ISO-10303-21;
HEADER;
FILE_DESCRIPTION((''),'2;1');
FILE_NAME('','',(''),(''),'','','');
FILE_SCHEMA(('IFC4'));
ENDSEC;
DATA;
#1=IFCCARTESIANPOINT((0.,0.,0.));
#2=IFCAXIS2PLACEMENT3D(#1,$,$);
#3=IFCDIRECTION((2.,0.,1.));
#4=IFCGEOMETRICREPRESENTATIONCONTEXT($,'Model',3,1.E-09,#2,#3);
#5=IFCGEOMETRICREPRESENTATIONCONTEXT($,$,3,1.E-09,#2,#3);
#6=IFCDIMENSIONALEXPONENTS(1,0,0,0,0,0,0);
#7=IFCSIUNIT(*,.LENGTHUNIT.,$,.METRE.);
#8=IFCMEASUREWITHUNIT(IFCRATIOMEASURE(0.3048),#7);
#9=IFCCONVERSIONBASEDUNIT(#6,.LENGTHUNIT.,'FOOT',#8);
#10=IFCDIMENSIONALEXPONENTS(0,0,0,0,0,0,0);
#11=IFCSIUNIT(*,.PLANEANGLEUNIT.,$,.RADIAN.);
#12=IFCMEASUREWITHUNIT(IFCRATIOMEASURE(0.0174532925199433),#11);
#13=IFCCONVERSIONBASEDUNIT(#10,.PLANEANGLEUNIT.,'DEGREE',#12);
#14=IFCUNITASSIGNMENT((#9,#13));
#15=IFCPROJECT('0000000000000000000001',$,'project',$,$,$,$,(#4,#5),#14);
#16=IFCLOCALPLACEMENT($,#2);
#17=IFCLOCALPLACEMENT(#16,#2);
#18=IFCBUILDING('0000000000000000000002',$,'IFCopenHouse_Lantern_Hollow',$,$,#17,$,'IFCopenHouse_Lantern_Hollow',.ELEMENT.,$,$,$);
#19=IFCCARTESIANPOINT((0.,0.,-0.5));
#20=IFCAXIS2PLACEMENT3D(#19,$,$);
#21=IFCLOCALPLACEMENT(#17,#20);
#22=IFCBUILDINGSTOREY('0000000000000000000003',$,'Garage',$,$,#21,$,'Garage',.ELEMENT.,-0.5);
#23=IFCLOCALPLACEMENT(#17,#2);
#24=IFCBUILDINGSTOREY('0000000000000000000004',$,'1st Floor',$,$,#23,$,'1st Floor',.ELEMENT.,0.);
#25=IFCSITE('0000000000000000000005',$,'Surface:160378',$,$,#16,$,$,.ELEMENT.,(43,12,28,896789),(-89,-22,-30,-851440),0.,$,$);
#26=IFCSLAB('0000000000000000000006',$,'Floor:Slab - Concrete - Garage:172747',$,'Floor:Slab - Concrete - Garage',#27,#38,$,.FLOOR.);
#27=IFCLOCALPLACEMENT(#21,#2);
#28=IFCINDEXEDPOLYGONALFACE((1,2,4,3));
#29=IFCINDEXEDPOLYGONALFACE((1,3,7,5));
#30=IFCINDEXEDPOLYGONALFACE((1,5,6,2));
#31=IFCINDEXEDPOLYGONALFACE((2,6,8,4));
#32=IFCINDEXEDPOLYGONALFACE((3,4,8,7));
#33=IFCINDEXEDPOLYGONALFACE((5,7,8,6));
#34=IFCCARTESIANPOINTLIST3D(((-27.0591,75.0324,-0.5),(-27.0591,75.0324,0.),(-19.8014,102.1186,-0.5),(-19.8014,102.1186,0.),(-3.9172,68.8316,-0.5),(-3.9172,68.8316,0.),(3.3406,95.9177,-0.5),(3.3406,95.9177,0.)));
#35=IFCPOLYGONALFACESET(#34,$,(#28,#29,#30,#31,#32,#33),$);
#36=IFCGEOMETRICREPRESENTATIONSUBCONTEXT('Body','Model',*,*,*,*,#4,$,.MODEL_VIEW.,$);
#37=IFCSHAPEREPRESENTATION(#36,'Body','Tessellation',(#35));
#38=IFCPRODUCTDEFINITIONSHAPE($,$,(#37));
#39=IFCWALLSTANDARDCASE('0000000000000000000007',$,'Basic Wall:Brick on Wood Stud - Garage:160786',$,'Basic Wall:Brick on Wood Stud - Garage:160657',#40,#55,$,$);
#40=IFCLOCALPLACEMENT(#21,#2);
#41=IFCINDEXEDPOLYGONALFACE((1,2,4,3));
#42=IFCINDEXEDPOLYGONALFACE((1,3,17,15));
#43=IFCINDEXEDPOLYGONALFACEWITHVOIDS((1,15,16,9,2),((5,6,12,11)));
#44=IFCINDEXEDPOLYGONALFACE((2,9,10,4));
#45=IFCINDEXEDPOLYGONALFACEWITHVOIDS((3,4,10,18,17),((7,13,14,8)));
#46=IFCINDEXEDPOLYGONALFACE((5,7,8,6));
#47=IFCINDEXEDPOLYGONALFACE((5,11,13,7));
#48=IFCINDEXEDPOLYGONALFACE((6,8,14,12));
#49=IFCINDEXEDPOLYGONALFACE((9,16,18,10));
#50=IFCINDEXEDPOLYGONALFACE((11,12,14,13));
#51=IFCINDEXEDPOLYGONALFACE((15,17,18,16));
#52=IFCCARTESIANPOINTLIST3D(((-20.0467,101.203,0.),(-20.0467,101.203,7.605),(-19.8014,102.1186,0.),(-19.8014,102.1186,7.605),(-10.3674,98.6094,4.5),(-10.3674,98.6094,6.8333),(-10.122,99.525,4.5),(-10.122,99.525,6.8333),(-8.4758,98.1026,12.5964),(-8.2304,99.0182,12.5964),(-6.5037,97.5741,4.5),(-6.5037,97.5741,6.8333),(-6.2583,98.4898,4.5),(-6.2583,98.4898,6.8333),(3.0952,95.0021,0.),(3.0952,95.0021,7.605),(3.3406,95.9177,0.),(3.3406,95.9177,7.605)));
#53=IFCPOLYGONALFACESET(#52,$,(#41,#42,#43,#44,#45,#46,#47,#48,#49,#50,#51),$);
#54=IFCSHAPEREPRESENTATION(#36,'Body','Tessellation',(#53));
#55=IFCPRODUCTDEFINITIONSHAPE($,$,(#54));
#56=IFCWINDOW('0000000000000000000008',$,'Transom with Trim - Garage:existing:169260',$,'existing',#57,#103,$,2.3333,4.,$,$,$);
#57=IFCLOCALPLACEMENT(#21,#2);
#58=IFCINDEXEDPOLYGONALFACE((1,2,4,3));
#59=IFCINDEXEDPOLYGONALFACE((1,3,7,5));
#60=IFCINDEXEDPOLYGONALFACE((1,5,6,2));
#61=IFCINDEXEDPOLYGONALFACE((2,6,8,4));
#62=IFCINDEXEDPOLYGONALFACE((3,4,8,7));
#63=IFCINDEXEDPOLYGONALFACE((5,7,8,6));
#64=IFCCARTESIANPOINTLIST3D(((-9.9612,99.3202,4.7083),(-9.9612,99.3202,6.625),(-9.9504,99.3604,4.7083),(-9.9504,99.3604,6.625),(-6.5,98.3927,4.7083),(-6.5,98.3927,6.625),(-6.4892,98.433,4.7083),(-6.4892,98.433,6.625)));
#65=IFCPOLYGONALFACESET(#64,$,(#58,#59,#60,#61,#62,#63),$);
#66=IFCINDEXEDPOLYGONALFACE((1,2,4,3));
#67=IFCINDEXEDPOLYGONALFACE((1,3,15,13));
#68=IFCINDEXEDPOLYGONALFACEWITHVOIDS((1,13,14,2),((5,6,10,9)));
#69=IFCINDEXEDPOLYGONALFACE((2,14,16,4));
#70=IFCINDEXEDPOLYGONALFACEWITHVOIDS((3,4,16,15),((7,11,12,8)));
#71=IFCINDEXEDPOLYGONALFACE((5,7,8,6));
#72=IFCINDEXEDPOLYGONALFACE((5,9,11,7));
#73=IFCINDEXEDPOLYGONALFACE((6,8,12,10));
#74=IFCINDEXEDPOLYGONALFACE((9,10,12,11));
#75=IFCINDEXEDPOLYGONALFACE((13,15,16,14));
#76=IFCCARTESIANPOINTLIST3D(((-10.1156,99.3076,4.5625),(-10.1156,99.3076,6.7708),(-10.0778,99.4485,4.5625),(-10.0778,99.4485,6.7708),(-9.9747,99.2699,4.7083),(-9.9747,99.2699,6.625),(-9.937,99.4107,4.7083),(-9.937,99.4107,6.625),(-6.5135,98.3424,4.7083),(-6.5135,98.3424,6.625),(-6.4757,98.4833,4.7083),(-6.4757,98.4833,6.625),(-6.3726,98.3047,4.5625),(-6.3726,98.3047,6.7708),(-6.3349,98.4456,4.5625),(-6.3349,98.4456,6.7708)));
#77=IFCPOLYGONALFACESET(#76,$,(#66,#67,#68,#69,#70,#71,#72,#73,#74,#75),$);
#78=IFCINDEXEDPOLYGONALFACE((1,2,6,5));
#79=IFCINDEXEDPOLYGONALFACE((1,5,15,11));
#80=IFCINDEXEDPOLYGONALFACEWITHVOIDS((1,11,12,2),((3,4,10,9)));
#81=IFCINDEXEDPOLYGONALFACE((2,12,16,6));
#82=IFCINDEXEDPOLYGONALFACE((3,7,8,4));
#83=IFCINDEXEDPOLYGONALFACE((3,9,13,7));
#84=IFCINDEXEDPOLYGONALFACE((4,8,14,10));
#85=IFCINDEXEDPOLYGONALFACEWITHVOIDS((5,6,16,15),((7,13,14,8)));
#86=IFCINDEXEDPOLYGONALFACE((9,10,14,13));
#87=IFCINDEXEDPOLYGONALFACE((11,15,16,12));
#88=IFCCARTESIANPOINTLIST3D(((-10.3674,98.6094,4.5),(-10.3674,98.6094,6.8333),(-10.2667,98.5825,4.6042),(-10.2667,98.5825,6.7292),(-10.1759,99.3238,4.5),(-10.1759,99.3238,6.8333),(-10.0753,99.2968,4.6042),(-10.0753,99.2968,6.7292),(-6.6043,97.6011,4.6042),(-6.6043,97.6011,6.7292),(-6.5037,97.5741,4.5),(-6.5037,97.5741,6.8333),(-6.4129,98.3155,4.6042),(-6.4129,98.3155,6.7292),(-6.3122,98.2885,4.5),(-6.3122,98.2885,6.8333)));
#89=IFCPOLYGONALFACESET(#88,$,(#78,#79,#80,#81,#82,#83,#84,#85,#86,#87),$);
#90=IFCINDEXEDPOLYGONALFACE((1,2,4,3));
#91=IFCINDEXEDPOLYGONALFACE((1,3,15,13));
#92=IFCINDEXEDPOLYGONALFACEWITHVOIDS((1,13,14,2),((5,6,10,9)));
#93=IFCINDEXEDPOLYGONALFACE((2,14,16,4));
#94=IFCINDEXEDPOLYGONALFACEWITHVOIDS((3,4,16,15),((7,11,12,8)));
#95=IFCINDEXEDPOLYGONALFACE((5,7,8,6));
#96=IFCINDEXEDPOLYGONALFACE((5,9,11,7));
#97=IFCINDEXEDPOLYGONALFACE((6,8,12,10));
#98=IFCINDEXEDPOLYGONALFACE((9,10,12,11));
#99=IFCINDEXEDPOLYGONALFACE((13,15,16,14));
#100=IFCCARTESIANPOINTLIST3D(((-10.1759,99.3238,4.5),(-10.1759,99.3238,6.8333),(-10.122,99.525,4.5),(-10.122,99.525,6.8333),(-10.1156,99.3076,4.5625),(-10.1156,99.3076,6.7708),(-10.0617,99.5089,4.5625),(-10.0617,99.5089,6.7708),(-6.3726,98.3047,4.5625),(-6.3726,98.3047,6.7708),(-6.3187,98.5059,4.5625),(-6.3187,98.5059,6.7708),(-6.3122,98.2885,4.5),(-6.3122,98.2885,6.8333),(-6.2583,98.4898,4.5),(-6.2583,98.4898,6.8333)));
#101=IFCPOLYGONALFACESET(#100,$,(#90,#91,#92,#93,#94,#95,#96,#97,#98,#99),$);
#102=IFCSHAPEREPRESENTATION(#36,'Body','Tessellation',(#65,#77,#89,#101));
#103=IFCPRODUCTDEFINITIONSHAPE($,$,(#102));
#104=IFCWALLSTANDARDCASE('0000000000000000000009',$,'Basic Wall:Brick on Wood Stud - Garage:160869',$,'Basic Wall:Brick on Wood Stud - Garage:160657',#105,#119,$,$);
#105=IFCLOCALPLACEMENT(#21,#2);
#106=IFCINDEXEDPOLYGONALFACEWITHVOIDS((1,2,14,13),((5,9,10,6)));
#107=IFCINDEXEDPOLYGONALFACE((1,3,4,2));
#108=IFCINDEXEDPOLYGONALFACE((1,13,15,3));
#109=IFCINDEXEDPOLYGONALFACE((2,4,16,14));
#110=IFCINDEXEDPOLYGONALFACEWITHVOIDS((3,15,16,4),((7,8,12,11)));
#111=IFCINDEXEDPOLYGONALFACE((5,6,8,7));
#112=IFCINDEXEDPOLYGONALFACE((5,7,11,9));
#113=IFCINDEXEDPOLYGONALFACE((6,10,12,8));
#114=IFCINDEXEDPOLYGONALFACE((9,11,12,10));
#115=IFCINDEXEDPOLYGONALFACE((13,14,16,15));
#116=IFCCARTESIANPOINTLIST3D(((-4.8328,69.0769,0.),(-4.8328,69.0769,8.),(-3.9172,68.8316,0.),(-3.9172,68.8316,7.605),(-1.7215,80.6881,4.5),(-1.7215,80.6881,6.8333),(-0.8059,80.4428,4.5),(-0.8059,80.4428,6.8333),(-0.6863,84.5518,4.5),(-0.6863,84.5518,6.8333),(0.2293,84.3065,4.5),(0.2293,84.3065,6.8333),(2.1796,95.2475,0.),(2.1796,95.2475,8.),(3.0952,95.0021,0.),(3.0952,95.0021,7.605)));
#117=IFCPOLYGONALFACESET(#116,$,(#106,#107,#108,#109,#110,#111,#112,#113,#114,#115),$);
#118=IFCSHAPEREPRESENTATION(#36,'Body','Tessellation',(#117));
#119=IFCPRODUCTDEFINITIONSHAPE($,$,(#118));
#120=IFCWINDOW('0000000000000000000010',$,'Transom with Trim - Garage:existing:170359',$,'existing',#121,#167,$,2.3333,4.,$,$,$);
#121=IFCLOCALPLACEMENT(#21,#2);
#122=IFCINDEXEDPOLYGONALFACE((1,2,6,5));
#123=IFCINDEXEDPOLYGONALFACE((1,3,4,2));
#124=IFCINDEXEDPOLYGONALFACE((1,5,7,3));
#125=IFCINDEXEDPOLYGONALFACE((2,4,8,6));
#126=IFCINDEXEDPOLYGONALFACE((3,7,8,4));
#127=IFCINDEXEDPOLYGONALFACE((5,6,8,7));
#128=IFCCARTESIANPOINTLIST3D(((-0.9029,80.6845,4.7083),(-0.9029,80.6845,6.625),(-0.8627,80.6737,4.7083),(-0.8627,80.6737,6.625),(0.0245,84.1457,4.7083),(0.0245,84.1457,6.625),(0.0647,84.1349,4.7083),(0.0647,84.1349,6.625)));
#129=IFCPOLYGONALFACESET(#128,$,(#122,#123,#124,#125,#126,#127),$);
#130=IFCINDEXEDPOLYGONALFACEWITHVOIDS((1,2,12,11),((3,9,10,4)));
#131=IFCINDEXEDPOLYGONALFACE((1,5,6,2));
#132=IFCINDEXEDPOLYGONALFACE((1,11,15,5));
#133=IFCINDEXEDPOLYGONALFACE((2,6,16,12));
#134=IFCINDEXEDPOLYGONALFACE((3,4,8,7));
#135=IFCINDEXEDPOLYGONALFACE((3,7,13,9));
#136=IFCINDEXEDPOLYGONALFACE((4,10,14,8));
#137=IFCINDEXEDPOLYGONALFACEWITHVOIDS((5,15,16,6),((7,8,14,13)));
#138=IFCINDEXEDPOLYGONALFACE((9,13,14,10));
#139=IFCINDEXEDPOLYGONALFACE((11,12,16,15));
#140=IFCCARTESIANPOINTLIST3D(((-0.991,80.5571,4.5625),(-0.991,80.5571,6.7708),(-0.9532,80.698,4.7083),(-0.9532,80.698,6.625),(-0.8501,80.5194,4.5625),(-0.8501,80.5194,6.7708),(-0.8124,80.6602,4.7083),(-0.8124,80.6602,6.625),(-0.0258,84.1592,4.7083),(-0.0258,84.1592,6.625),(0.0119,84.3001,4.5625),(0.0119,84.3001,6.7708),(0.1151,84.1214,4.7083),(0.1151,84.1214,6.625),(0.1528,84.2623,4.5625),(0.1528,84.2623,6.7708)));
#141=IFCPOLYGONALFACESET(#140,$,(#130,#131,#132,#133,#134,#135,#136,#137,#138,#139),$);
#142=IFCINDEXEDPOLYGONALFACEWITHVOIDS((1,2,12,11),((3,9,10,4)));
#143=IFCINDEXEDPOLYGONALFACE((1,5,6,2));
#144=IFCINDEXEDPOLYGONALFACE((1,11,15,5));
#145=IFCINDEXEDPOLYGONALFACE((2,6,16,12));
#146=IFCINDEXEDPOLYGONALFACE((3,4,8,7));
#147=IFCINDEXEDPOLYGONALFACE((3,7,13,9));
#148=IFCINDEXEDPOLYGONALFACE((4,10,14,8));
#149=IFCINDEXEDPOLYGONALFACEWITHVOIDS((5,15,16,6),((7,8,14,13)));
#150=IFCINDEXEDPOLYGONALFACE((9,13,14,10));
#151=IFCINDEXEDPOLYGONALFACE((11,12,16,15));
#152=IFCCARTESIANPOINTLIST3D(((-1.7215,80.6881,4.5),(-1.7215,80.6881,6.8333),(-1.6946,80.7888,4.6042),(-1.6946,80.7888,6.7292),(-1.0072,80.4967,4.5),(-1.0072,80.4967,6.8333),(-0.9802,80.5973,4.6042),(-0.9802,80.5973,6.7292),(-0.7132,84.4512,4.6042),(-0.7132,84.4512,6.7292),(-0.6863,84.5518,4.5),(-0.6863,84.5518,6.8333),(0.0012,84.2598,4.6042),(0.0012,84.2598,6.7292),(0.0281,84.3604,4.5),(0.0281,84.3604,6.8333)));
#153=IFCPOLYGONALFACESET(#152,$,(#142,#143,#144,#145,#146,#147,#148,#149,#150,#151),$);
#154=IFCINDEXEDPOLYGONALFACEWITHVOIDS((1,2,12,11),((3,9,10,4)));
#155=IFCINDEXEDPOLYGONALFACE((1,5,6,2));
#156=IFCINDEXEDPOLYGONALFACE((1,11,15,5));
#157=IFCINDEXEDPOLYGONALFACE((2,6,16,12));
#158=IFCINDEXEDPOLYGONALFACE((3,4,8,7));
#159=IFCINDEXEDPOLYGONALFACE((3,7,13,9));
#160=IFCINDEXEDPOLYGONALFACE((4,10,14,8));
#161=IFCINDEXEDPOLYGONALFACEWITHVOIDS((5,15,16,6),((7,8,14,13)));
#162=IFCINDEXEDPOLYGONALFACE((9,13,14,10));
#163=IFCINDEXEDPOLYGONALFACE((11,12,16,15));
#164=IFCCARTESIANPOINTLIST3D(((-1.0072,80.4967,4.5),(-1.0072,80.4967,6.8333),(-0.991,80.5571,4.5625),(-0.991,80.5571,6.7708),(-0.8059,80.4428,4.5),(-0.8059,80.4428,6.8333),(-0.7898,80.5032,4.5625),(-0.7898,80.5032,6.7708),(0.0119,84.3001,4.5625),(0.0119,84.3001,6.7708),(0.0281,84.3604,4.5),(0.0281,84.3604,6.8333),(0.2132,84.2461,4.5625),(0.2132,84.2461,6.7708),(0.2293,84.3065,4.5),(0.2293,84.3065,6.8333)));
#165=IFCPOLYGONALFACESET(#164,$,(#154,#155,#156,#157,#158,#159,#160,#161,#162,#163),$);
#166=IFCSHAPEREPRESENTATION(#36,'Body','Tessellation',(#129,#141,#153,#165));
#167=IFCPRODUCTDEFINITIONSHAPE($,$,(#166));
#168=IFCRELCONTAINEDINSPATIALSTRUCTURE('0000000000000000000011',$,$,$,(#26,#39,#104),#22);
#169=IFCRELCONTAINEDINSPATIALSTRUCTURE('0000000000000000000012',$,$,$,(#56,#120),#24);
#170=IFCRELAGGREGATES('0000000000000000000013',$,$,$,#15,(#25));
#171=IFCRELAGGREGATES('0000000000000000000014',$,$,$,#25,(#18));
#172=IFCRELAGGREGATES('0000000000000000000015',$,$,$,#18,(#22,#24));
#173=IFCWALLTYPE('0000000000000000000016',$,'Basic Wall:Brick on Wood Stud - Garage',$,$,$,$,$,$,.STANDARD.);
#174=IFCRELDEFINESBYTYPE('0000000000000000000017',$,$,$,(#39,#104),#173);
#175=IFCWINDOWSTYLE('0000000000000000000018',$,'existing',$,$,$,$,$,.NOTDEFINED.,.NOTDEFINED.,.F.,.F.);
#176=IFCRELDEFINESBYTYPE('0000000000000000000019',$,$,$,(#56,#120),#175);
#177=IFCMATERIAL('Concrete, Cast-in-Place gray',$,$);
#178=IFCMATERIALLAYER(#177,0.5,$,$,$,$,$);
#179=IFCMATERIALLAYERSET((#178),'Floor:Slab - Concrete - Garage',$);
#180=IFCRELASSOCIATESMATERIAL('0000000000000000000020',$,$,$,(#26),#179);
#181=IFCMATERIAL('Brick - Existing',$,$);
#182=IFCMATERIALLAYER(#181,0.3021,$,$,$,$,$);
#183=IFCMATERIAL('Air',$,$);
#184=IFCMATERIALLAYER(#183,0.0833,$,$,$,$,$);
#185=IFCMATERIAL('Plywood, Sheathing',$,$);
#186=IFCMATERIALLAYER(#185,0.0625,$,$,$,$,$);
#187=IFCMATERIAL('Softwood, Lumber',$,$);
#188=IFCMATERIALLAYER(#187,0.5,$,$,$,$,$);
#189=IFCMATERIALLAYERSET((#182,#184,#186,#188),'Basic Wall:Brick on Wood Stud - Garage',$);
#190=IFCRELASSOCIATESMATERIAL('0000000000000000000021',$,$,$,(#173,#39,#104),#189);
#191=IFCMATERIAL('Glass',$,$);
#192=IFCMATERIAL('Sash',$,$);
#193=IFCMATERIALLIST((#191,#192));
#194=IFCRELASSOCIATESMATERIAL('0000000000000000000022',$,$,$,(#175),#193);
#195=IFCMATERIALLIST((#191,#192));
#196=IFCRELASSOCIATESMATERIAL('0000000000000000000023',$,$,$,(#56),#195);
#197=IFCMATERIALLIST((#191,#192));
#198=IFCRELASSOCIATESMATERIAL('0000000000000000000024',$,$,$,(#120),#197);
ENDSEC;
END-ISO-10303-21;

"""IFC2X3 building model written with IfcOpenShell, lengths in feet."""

from ifc_helpers import new_model, entity, si_unit, converted_unit, direction, frame, frame_2d, origin, place, context, subcontext, project, spatial, polyline, rectangle, outline, extrude, clip, bounded_halfspace, source, transform, mapped, material, material_list, layer, layer_set, layer_usage, type_object, type_shapes, element, fill, save


model = new_model("IFC2X3")

# Units and contexts
model_context = context("Model", 3, precision=1e-09, world=origin(), true_north=direction((2.0, 0.0, 1.0)))
context_of_model = context(None, 3, precision=1e-09, world=origin(), true_north=direction((2.0, 0.0, 1.0)))
body_context = subcontext(model_context, "Body", "Model", "MODEL_VIEW")
ifc_project = project(units=[converted_unit("LENGTHUNIT", "FOOT", entity("IfcRatioMeasure", 0.3048), si_unit("LENGTHUNIT", "METRE"), dimensions=[1, 0, 0, 0, 0, 0, 0]), converted_unit("PLANEANGLEUNIT", "DEGREE", entity("IfcRatioMeasure", 0.0174532925199433), si_unit("PLANEANGLEUNIT", "RADIAN"), dimensions=[0, 0, 0, 0, 0, 0, 0])], contexts=[model_context, context_of_model])

# Site, building, storey
site_placement = place(None, origin())
site = spatial("IfcSite", under=ifc_project, at=site_placement, Name="Surface:160378", CompositionType="ELEMENT", RefLatitude=(43, 12, 28, 896789), RefLongitude=(-89, -22, -30, -851440), RefElevation=0.0)
building_placement = place(site_placement, origin())
building = spatial("IfcBuilding", under=site, at=building_placement, Name="IFCopenHouse_Lantern_Hollow", LongName="IFCopenHouse_Lantern_Hollow", CompositionType="ELEMENT")
storey_1_placement = place(building_placement, frame((0.0, 0.0, -0.5)))
storey_1 = spatial("IfcBuildingStorey", under=building, at=storey_1_placement, Name="Garage", LongName="Garage", CompositionType="ELEMENT", Elevation=-0.5)

# Slab
ifc_material_1 = material(Name="Concrete, Cast-in-Place gray")
ifc_layer_1 = layer(ifc_material_1, 0.5)
ifc_layer_set_1 = layer_set([ifc_layer_1], Name="Floor:Slab - Concrete - Garage")
ifc_layer_usage_1 = layer_usage(ifc_layer_set_1, "AXIS3", "POSITIVE", 0.0)
slab_placement = place(storey_1_placement, origin())
element("IfcSlab", 1, at=slab_placement, inside=storey_1, material=ifc_layer_usage_1, Name="Floor:Slab - Concrete - Garage:172747", ObjectType="Floor:Slab - Concrete - Garage", PredefinedType="FLOOR", context=body_context, shape_type="SweptSolid", body=[
    extrude(rectangle(XDim=28.0417, YDim=23.9583, at=frame_2d((0.0, 0.0), x_axis=(1.0, 0.0))), frame((-11.8593, 85.4751, 0.0), z_axis=(0.0, 0.0, -1.0), x_axis=(-0.258819, -0.965926, 0.0)), (0.0, 0.0, 1.0), 0.5),
])

# Wall, opening
ifc_material_2 = material(Name="Brick - Existing")
ifc_layer_2 = layer(ifc_material_2, 0.3021)
ifc_material_3 = material(Name="Air")
ifc_layer_3 = layer(ifc_material_3, 0.0833)
ifc_material_4 = material(Name="Plywood, Sheathing")
ifc_layer_4 = layer(ifc_material_4, 0.0625)
ifc_material_5 = material(Name="Softwood, Lumber")
ifc_layer_5 = layer(ifc_material_5, 0.5)
ifc_layer_set_2 = layer_set([ifc_layer_2, ifc_layer_3, ifc_layer_4, ifc_layer_5], Name="Basic Wall:Brick on Wood Stud - Garage")
ifc_layer_usage_2 = layer_usage(ifc_layer_set_2, "AXIS2", "NEGATIVE", 0.474)
wall_type = type_object("IfcWallType", Name="Basic Wall:Brick on Wood Stud - Garage", PredefinedType="STANDARD", material=ifc_layer_set_2)
wall_1_placement = place(storey_1_placement, frame((-19.9241, 101.6608, 0.0), z_axis=(0.0, 0.0, 1.0), x_axis=(0.965926, -0.258819, 0.0)))
wall_1 = element("IfcWallStandardCase", 2, at=wall_1_placement, inside=storey_1, type_object=wall_type, material=ifc_layer_usage_2, Name="Basic Wall:Brick on Wood Stud - Garage:160786", ObjectType="Basic Wall:Brick on Wood Stud - Garage:160657", context=body_context, shape_type="Clipping", body=[
    clip(clip(extrude(rectangle(XDim=23.9583, YDim=0.9479, at=frame_2d((11.9792, 0.0), x_axis=(-1.0, 0.0))), origin(), (0.0, 0.0, 1.0), 12.5964), bounded_halfspace(frame((11.9792, -0.474, 12.5964), z_axis=(0.384615, 0.0, 0.923077), x_axis=(0.0, 1.0, 0.0)), False, frame((11.9792, -0.474, 12.5964)), polyline([(0.0, 0.0), (11.0313, 0.0), (11.9792, 0.0), (11.9792, 0.9479), (0.0, 0.9479), (0.0, 0.0)]))), bounded_halfspace(frame((0.0, -0.474, 7.605), z_axis=(-0.384615, 0.0, 0.923077), x_axis=(0.0, -1.0, 0.0)), False, frame((0.0, -0.474, 7.605)), polyline([(0.0, 0.0), (0.9479, 0.0), (11.9792, 0.0), (11.9792, 0.9479), (0.0, 0.9479), (0.0, 0.0)]))),
])
opening_1_placement = place(wall_1_placement, frame((10.0208, -0.474, 4.5)))
opening_1 = element("IfcOpeningElement", 3, at=opening_1_placement, cuts=wall_1, ObjectType="Opening", context=body_context, shape_type="SweptSolid", body=[
    extrude(rectangle(XDim=2.3333, YDim=4.0, at=frame_2d((1.1667, 2.0), x_axis=(-1.0, 0.0))), frame((0.0, 0.0, 0.0), z_axis=(0.0, 1.0, 0.0), x_axis=(0.0, 0.0, 1.0)), (0.0, 0.0, 1.0), 0.9479),
])

# Shared definitions
storey_2_placement = place(building_placement, origin())
storey_2 = spatial("IfcBuildingStorey", under=building, at=storey_2_placement, Name="1st Floor", LongName="1st Floor", CompositionType="ELEMENT", Elevation=0.0)

# Window
ifc_material_6 = material(Name="Glass")
ifc_material_7 = material(Name="Sash")
ifc_material_list_1 = material_list([ifc_material_6, ifc_material_7])
ifc_material_list_2 = material_list([ifc_material_6, ifc_material_7])
window_style = type_object("IfcWindowStyle", Name="existing", ConstructionType="NOTDEFINED", OperationType="NOTDEFINED", ParameterTakesPrecedence=False, Sizeable=False, material=ifc_material_list_2)
shared_shape_1 = source(origin(), body_context, "Body", "SweptSolid", [
    extrude(rectangle(XDim=3.5833, YDim=0.0417, at=frame_2d((0.0, 0.0), x_axis=(1.0, 0.0))), frame((2.25, 0.8125, 0.2083)), (0.0, 0.0, 1.0), 1.9167),
    extrude(outline(polyline([(-1.9375, -1.1042), (1.9375, -1.1042), (1.9375, 1.1042), (-1.9375, 1.1042), (-1.9375, -1.1042)]), holes=[polyline([(-1.7917, -0.9583), (-1.7917, 0.9583), (1.7917, 0.9583), (1.7917, -0.9583), (-1.7917, -0.9583)])]), frame((2.25, 0.8854, 1.1667), z_axis=(0.0, -1.0, 0.0), x_axis=(-1.0, 0.0, 0.0)), (0.0, 0.0, 1.0), 0.1458),
    extrude(outline(polyline([(-2.0, -1.1667), (2.0, -1.1667), (2.0, 1.1667), (-2.0, 1.1667), (-2.0, -1.1667)]), holes=[polyline([(-1.8958, -1.0625), (-1.8958, 1.0625), (1.8958, 1.0625), (1.8958, -1.0625), (-1.8958, -1.0625)])]), frame((2.25, 0.7396, 1.1667), z_axis=(0.0, -1.0, 0.0), x_axis=(-1.0, 0.0, 0.0)), (0.0, 0.0, 1.0), 0.7396),
    extrude(outline(polyline([(-1.1667, -2.0), (1.1667, -2.0), (1.1667, 2.0), (-1.1667, 2.0), (-1.1667, -2.0)]), holes=[polyline([(-1.1042, -1.9375), (-1.1042, 1.9375), (1.1042, 1.9375), (1.1042, -1.9375), (-1.1042, -1.9375)])]), frame((2.25, 0.9479, 1.1667), z_axis=(0.0, -1.0, 0.0), x_axis=(0.0, 0.0, -1.0)), (0.0, 0.0, 1.0), 0.2083),
])
type_shapes(window_style, [shared_shape_1])
window_1_placement = place(storey_2_placement, frame((-10.6088, 98.6741, 4.0), z_axis=(0.0, 0.0, 1.0), x_axis=(0.965926, -0.258819, 0.0)))
window_1 = element("IfcWindow", 4, at=window_1_placement, inside=storey_2, type_object=window_style, material=ifc_material_list_1, Name="Transom with Trim - Garage:existing:169260", ObjectType="existing", OverallHeight=2.3333, OverallWidth=4.0, context=body_context, shape_type="MappedRepresentation", body=[
    mapped(shared_shape_1, transform((0.0, 0.0, 0.0), scale=1.0)),
])
fill(opening_1, window_1)

# Wall, opening, window
ifc_layer_usage_3 = layer_usage(ifc_layer_set_2, "AXIS2", "NEGATIVE", 0.474)
wall_2_placement = place(storey_1_placement, frame((2.6374, 95.1248, 0.0), z_axis=(0.0, 0.0, 1.0), x_axis=(-0.258819, -0.965926, 0.0)))
wall_2 = element("IfcWallStandardCase", 5, at=wall_2_placement, inside=storey_1, type_object=wall_type, material=ifc_layer_usage_3, Name="Basic Wall:Brick on Wood Stud - Garage:160869", ObjectType="Basic Wall:Brick on Wood Stud - Garage:160657", context=body_context, shape_type="Clipping", body=[
    clip(extrude(rectangle(XDim=27.0938, YDim=0.9479, at=frame_2d((13.5469, 0.0), x_axis=(-1.0, 0.0))), origin(), (0.0, 0.0, 1.0), 8.0), bounded_halfspace(frame((0.0, -0.474, 8.0), z_axis=(0.0, 0.384615, 0.923077), x_axis=(-1.0, 0.0, 0.0)), False, frame((0.0, -0.474, 8.0)), polyline([(0.0, 0.0), (26.1458, 0.0), (27.0938, 0.0), (27.0938, 0.9479), (0.0, 0.9479), (0.0, 0.0)]))),
])
opening_2_placement = place(wall_2_placement, frame((11.0729, -0.474, 4.5)))
opening_2 = element("IfcOpeningElement", 6, at=opening_2_placement, cuts=wall_2, ObjectType="Opening", context=body_context, shape_type="SweptSolid", body=[
    extrude(rectangle(XDim=2.3333, YDim=4.0, at=frame_2d((1.1667, 2.0), x_axis=(-1.0, 0.0))), frame((0.0, 0.0, 0.0), z_axis=(0.0, 1.0, 0.0), x_axis=(0.0, 0.0, 1.0)), (0.0, 0.0, 1.0), 0.9479),
])
ifc_material_list_3 = material_list([ifc_material_6, ifc_material_7])
window_2_placement = place(storey_2_placement, frame((-0.6216, 84.7933, 4.0), z_axis=(0.0, 0.0, 1.0), x_axis=(-0.258819, -0.965926, 0.0)))
window_2 = element("IfcWindow", 7, at=window_2_placement, inside=storey_2, type_object=window_style, material=ifc_material_list_3, Name="Transom with Trim - Garage:existing:170359", ObjectType="existing", OverallHeight=2.3333, OverallWidth=4.0, context=body_context, shape_type="MappedRepresentation", body=[
    mapped(shared_shape_1, transform((0.0, 0.0, 0.0), scale=1.0)),
])
fill(opening_2, window_2)

save(model, "model.ifc")
